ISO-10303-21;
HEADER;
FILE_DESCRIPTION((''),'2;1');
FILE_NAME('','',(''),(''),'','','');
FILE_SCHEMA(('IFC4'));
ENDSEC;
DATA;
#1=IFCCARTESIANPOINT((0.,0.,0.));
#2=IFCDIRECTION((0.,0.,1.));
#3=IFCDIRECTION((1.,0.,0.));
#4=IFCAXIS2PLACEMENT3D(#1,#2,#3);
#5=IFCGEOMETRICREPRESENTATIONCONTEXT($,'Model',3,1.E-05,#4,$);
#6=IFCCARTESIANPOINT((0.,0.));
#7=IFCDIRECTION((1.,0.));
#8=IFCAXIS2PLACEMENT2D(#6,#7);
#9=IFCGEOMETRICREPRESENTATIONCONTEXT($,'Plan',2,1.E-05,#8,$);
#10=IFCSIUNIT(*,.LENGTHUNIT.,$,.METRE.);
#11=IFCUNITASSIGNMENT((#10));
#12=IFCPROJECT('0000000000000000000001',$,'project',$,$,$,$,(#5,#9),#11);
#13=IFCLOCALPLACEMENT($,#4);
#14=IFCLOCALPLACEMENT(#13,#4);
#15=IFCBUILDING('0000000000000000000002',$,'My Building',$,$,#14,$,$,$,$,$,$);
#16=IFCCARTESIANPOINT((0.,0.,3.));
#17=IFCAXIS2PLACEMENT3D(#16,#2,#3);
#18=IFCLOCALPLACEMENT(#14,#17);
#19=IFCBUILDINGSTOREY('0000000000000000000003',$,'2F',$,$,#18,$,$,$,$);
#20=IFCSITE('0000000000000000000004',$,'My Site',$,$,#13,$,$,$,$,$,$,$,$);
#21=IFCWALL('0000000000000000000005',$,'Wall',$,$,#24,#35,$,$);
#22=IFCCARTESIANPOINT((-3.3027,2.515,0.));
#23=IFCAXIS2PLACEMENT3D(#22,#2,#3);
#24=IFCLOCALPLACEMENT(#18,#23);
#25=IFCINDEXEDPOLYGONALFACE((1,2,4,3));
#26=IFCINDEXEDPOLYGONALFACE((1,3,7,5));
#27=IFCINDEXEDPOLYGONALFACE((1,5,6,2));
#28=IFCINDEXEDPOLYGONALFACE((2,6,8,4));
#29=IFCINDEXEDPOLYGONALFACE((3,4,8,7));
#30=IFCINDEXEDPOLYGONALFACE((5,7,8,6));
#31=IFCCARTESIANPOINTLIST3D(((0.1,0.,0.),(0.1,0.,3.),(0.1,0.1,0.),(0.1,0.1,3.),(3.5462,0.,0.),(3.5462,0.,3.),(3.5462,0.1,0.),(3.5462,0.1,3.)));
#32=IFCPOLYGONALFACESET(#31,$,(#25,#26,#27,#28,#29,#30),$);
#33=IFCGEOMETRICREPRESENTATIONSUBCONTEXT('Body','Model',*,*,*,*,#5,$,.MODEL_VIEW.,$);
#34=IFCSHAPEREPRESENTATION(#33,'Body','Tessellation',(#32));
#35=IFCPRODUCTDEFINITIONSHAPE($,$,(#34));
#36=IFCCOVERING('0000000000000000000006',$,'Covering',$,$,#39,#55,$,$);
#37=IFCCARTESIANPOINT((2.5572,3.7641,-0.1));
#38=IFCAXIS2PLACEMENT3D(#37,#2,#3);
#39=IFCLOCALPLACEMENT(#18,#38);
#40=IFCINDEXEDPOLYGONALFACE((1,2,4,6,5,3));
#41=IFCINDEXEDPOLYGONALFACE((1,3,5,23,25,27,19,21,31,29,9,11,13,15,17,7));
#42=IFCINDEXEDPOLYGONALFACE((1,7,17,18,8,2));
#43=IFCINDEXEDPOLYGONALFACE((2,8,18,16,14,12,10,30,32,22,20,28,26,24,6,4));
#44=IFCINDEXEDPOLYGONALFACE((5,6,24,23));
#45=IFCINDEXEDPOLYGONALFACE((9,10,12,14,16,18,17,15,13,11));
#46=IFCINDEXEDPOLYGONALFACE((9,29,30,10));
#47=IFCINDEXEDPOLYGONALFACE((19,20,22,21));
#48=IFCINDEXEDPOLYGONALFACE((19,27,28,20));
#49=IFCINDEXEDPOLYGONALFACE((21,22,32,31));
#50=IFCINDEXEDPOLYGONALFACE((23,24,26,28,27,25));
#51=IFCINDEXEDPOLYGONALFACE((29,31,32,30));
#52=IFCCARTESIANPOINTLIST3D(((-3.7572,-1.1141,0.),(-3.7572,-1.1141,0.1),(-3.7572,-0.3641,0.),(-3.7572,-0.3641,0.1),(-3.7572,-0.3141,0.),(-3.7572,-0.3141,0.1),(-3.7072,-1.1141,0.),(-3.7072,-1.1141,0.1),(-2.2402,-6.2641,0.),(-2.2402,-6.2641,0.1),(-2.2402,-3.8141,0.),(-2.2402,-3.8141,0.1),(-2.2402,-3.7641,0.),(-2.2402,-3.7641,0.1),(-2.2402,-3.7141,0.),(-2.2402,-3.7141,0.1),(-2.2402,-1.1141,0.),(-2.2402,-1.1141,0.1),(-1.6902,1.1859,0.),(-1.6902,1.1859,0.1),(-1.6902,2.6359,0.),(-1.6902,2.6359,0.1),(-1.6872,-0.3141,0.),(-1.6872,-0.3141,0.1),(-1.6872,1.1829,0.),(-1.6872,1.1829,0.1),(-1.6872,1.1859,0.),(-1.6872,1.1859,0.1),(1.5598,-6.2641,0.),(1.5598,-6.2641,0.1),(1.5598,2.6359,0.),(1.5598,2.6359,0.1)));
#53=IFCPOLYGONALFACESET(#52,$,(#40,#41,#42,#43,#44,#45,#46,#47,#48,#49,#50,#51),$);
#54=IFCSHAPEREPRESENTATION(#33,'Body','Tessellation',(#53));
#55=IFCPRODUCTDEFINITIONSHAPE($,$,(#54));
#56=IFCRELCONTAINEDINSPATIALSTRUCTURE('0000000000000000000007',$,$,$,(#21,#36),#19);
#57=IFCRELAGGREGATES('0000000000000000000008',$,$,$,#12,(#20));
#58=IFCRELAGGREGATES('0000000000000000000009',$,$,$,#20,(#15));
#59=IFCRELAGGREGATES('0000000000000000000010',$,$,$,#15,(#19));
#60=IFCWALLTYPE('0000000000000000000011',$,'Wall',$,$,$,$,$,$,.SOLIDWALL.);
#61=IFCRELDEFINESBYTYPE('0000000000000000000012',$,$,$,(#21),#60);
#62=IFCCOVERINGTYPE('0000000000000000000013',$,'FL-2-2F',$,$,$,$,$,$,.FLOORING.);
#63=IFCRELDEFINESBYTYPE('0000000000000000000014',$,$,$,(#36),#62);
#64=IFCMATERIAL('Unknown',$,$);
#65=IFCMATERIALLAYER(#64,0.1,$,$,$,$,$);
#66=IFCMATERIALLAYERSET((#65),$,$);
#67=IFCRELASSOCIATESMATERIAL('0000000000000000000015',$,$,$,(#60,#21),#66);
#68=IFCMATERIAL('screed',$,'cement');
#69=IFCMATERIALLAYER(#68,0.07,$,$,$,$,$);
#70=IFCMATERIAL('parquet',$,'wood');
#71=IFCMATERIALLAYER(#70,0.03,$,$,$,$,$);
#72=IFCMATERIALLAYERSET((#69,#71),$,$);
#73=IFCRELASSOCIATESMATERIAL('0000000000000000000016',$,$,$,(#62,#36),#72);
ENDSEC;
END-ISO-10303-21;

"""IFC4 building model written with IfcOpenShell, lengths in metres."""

from ifc_helpers import new_model, si_unit, frame, origin_with_axes, origin_2d_with_axis, place, context, subcontext, project, spatial, line, indexed_curve, outline, extrude, material, layer, layer_set, layer_usage, type_object, element, save


model = new_model("IFC4")

# Units and contexts
model_context = context("Model", 3, precision=1e-05, world=origin_with_axes())
plan_context = context("Plan", 2, precision=1e-05, world=origin_2d_with_axis())
body_context_1 = subcontext(model_context, "Body", "Model", "MODEL_VIEW")
ifc_project = project(units=[si_unit("LENGTHUNIT", "METRE")], contexts=[model_context, plan_context])

# Site, building, storey
site_placement = place(None, origin_with_axes())
site = spatial("IfcSite", under=ifc_project, at=site_placement, Name="My Site")
building_placement = place(site_placement, origin_with_axes())
building = spatial("IfcBuilding", under=site, at=building_placement, Name="My Building")
storey_placement = place(building_placement, frame((0.0, 0.0, 3.0), z_axis=(0.0, 0.0, 1.0), x_axis=(1.0, 0.0, 0.0)))
storey = spatial("IfcBuildingStorey", under=building, at=storey_placement, Name="2F")

# Shared definitions
ifc_material_1 = material(Name="Unknown")
ifc_layer_1 = layer(ifc_material_1, 0.1)
ifc_layer_set_1 = layer_set([ifc_layer_1])
wall_type_1 = type_object("IfcWallType", Name="Wall", PredefinedType="SOLIDWALL", material=ifc_layer_set_1)

# Wall
ifc_layer_usage_1 = layer_usage(ifc_layer_set_1, "AXIS2", "POSITIVE", 0.0)
wall_1_placement = place(storey_placement, frame((-3.3027, 2.515, 0.0), z_axis=(0.0, 0.0, 1.0), x_axis=(1.0, 0.0, 0.0)))
element("IfcWall", 1, at=wall_1_placement, inside=storey, type_object=wall_type_1, material=ifc_layer_usage_1, Name="Wall", context=body_context_1, shape_type="SweptSolid", body=[
    extrude(outline(indexed_curve([(0.1, 0.0), (0.1, 0.1), (3.5462, 0.1), (3.5462, 0.0)], segments=[line(1, 2, 3, 4, 1)])), origin_with_axes(), (0.0, 0.0, 1.0), 3.0),
])

# Covering
ifc_material_2 = material(Name="screed", Category="cement")
ifc_layer_2 = layer(ifc_material_2, 0.07)
ifc_material_3 = material(Name="parquet", Category="wood")
ifc_layer_3 = layer(ifc_material_3, 0.03)
ifc_layer_set_2 = layer_set([ifc_layer_2, ifc_layer_3])
ifc_layer_usage_2 = layer_usage(ifc_layer_set_2, "AXIS3", "POSITIVE", 0.0)
covering_type = type_object("IfcCoveringType", Name="FL-2-2F", PredefinedType="FLOORING", material=ifc_layer_set_2)
covering_placement = place(storey_placement, frame((2.5572, 3.7641, -0.1), z_axis=(0.0, 0.0, 1.0), x_axis=(1.0, 0.0, 0.0)))
element("IfcCovering", 2, at=covering_placement, inside=storey, type_object=covering_type, material=ifc_layer_usage_2, Name="Covering", context=body_context_1, shape_type="SweptSolid", body=[
    extrude(outline(indexed_curve([(-1.6902, 1.1859), (-1.6902, 2.6359), (1.5598, 2.6359), (1.5598, -6.2641), (-2.2402, -6.2641), (-2.2402, -3.8141), (-2.2402, -3.7641), (-2.2402, -3.7141), (-2.2402, -1.1141), (-3.7072, -1.1141), (-3.7572, -1.1141), (-3.7572, -0.3641), (-3.7572, -0.3141), (-1.6872, -0.3141), (-1.6872, 1.1829), (-1.6872, 1.1859)], segments=[line(1, 2, 3, 4, 5, 6, 7, 8, 9, 10, 11, 12, 13, 14, 15, 16, 1)])), origin_with_axes(), (0.0, 0.0, 1.0), 0.1),
])

save(model, "model.ifc")
